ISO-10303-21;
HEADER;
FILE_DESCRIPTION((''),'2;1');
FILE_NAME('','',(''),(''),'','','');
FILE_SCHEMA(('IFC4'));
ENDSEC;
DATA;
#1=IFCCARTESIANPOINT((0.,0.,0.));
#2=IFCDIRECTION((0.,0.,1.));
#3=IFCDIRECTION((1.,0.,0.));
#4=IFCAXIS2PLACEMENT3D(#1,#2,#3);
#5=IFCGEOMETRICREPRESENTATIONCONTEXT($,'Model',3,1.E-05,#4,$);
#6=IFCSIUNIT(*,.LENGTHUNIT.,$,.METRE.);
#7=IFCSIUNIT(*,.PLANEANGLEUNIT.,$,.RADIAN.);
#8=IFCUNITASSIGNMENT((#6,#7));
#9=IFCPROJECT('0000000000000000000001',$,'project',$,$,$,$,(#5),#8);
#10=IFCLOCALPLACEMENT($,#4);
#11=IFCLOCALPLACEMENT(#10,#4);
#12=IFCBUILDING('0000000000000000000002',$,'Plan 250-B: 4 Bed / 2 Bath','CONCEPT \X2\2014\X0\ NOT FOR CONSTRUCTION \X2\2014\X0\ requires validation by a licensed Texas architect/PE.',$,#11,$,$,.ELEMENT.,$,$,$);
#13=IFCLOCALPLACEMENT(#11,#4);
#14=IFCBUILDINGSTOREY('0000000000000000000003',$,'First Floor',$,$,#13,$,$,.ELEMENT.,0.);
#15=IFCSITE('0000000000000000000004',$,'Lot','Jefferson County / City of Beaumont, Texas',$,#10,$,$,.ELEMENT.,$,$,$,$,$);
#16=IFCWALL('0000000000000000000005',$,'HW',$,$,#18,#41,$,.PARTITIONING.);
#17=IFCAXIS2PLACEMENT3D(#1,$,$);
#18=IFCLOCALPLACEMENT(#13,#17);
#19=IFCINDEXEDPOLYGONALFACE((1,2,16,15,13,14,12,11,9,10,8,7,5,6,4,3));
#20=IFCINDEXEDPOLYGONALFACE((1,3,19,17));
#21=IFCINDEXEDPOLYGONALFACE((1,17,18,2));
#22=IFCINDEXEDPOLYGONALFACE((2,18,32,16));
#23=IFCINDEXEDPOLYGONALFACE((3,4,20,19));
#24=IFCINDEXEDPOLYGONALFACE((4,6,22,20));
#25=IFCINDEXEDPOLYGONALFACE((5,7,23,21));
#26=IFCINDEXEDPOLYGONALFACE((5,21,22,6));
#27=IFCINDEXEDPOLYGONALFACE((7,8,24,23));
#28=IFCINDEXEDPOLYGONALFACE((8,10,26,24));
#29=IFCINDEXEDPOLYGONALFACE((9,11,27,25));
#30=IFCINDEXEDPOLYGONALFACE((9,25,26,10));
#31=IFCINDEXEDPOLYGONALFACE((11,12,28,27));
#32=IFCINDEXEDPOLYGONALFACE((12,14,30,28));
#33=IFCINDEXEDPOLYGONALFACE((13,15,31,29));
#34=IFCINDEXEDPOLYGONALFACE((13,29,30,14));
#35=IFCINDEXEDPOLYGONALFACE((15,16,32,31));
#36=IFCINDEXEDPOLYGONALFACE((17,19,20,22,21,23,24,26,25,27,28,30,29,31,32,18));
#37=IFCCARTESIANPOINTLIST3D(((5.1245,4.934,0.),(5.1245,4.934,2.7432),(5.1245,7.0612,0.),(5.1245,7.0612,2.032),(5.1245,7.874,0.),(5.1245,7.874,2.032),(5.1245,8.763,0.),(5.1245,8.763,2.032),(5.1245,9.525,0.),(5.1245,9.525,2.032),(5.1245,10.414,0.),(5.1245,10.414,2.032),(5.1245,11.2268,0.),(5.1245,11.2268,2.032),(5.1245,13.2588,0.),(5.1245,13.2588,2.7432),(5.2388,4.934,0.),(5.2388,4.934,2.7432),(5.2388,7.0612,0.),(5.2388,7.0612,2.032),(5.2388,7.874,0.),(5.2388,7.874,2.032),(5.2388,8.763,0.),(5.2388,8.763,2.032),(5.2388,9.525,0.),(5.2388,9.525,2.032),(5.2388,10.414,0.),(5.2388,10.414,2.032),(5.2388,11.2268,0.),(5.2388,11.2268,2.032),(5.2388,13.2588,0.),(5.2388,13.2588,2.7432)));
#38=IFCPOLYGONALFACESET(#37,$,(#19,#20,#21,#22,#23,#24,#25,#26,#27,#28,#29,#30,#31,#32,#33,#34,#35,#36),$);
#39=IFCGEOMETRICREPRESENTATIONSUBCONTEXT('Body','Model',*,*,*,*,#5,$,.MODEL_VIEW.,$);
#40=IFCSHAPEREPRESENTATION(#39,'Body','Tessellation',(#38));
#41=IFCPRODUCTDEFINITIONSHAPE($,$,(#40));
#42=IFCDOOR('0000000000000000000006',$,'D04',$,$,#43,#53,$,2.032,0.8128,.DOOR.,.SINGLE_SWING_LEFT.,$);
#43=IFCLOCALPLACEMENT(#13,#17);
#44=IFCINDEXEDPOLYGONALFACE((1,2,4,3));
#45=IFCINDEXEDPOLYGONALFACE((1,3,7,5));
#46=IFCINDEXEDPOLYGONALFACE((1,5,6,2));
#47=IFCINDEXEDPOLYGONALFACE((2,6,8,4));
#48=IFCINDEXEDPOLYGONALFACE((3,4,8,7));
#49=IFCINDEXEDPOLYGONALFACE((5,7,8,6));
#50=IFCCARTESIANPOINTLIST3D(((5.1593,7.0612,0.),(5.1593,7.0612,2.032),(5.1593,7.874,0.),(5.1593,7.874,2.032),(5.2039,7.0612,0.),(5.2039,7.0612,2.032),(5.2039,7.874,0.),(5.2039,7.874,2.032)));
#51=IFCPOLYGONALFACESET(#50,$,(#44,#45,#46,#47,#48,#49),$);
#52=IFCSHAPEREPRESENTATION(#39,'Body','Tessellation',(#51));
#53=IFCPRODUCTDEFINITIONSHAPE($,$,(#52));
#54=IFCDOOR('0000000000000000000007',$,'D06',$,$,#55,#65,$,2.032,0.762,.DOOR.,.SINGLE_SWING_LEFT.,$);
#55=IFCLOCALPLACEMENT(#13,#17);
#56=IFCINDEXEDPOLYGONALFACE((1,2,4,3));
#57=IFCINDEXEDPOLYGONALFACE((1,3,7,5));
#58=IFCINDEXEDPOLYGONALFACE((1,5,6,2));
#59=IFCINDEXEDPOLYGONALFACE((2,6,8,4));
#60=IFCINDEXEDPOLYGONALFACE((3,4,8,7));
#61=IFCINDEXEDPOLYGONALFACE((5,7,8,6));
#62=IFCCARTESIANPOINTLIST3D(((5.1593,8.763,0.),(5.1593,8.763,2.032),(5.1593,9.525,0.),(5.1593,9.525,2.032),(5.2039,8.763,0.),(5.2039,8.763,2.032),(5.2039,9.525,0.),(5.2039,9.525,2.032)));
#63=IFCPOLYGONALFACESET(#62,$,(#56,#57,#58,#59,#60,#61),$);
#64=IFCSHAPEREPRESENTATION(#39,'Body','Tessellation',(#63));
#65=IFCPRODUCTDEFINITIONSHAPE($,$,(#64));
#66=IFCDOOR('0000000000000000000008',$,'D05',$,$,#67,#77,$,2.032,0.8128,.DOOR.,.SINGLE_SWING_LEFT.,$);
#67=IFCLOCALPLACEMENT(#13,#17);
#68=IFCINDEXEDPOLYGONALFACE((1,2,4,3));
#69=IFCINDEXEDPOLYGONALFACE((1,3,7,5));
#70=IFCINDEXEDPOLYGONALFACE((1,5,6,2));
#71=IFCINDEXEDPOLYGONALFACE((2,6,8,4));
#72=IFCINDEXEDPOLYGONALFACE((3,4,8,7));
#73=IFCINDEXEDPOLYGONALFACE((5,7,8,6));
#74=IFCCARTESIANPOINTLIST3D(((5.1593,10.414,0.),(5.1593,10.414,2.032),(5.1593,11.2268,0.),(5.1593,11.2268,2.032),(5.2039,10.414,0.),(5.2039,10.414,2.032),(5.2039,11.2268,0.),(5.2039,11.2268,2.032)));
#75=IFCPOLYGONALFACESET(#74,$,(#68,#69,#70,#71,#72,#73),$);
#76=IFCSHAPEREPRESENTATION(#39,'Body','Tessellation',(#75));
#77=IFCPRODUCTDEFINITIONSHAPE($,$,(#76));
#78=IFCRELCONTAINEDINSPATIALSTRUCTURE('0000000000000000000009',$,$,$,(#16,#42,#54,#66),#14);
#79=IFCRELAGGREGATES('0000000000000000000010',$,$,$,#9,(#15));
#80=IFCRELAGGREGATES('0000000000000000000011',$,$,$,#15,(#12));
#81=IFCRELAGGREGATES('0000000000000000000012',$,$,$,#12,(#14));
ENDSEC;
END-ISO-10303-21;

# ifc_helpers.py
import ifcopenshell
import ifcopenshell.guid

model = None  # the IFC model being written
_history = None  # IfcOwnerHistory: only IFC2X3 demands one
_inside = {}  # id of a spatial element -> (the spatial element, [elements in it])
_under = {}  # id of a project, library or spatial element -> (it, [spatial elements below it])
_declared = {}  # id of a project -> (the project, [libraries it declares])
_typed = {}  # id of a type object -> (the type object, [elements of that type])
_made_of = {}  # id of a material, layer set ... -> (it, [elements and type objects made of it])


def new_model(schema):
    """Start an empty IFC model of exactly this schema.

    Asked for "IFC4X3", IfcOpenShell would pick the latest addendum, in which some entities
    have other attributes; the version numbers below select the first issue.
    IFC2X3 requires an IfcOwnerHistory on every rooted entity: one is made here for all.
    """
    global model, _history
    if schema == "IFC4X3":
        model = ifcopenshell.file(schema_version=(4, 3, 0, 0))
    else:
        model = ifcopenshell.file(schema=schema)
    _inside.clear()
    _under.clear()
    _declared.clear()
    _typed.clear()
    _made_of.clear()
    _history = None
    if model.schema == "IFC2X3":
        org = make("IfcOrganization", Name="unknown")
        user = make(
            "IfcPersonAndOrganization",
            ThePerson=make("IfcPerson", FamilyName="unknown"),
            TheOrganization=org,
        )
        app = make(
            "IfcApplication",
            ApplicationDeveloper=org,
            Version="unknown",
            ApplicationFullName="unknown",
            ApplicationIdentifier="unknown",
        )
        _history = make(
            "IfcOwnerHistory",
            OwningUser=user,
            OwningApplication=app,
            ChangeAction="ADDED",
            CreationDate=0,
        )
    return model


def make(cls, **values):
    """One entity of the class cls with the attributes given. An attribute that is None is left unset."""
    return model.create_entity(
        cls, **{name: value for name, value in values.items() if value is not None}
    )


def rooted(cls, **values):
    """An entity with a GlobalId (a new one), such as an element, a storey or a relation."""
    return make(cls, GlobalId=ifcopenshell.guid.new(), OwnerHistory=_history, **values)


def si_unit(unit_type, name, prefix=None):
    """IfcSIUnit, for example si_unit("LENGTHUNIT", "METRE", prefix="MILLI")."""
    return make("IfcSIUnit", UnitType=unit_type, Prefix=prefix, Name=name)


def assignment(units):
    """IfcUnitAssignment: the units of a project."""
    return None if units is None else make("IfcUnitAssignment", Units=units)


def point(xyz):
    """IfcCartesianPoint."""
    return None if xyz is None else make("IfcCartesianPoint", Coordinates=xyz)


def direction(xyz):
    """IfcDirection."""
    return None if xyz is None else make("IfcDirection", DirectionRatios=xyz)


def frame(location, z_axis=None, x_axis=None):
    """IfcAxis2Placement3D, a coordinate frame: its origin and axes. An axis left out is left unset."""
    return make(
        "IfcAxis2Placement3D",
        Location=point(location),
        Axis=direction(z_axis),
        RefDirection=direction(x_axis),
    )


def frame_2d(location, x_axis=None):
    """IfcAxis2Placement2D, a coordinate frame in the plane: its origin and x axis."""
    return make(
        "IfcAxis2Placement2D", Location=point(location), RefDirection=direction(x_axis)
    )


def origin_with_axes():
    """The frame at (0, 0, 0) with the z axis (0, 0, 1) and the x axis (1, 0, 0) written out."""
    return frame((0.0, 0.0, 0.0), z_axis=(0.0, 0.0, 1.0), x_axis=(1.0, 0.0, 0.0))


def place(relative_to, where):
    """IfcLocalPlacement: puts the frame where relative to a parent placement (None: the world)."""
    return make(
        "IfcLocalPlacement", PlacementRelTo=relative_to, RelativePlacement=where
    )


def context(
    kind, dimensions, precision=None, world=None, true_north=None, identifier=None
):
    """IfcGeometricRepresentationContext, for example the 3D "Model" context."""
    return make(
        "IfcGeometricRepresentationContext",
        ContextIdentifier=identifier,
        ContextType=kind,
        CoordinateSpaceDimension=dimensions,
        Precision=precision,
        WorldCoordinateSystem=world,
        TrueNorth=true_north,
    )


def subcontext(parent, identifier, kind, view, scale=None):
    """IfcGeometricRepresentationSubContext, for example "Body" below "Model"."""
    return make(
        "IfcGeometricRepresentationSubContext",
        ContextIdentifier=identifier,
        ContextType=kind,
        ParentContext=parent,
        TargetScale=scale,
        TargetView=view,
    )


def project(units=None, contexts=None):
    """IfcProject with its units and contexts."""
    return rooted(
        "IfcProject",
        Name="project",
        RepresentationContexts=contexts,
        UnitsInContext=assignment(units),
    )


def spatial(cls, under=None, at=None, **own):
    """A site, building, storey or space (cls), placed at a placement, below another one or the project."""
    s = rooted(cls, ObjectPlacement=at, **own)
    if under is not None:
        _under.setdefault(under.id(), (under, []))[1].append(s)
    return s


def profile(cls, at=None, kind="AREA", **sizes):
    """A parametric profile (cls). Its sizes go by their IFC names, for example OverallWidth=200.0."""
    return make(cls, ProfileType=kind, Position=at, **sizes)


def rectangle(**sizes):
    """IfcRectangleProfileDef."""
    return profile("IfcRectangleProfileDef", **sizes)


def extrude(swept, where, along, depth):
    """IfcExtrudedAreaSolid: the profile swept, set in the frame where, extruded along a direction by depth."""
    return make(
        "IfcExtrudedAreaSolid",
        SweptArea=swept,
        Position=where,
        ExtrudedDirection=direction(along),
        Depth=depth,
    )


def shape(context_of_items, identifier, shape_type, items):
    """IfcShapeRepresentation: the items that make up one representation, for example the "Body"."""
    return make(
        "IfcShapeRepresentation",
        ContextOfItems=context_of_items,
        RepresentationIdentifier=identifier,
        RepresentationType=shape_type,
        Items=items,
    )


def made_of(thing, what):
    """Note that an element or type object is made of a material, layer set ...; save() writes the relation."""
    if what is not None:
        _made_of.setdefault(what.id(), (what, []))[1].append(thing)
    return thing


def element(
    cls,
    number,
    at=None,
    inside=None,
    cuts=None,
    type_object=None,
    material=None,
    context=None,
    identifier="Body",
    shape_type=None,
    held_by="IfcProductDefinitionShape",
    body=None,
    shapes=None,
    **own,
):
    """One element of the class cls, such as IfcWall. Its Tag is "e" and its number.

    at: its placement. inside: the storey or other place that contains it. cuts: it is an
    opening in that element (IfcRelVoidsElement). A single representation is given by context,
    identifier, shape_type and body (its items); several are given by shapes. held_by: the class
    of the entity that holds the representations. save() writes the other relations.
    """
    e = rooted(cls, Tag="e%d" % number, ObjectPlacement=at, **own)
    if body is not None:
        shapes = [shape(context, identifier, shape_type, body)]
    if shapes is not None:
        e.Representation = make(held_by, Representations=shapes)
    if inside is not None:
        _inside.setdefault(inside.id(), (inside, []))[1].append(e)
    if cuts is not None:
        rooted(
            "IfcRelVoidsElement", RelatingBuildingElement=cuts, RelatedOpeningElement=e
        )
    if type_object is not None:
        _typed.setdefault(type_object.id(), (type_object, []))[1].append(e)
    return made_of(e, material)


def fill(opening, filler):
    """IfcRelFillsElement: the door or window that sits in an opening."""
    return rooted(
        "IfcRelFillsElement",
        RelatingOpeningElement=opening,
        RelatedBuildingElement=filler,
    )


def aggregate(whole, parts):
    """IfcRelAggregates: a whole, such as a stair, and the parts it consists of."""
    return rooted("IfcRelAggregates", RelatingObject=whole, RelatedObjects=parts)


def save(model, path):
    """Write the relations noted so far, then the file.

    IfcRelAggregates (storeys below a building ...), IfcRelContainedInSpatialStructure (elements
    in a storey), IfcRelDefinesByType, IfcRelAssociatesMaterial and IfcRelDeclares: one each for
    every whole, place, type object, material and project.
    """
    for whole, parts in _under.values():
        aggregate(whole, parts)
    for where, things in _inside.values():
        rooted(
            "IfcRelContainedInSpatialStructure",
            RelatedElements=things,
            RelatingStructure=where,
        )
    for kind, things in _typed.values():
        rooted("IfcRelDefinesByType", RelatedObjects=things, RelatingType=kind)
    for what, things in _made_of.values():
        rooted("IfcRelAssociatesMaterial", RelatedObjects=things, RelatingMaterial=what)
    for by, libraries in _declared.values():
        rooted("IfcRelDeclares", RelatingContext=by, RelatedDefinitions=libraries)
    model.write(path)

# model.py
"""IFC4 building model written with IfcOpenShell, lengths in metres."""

from ifc_helpers import new_model, si_unit, frame, frame_2d, origin_with_axes, place, context, subcontext, project, spatial, rectangle, extrude, element, fill, save


model = new_model("IFC4")

# Units and contexts
model_context = context("Model", 3, precision=1e-05, world=origin_with_axes())
body_context = subcontext(model_context, "Body", "Model", "MODEL_VIEW")
ifc_project = project(units=[si_unit("LENGTHUNIT", "METRE"), si_unit("PLANEANGLEUNIT", "RADIAN")], contexts=[model_context])

# Site, building, storey
site_placement = place(None, origin_with_axes())
site = spatial("IfcSite", under=ifc_project, at=site_placement, Name="Lot", Description="Jefferson County / City of Beaumont, Texas", CompositionType="ELEMENT")
building_placement = place(site_placement, origin_with_axes())
building = spatial("IfcBuilding", under=site, at=building_placement, Name="Plan 250-B: 4 Bed / 2 Bath", Description="CONCEPT — NOT FOR CONSTRUCTION — requires validation by a licensed Texas architect/PE.", CompositionType="ELEMENT")
storey_placement = place(building_placement, origin_with_axes())
storey = spatial("IfcBuildingStorey", under=building, at=storey_placement, Name="First Floor", CompositionType="ELEMENT", Elevation=0.0)

# Wall, openings, doors
wall_1_placement = place(storey_placement, frame((5.1816, 4.934, 0.0), z_axis=(0.0, 0.0, 1.0), x_axis=(0.0, 1.0, 0.0)))
wall_1 = element("IfcWall", 1, at=wall_1_placement, inside=storey, Name="HW", PredefinedType="PARTITIONING", context=body_context, shape_type="SweptSolid", body=[
    extrude(rectangle(XDim=8.3248, YDim=0.1143, at=frame_2d((4.1624, 0.0), x_axis=(1.0, 0.0))), origin_with_axes(), (0.0, 0.0, 1.0), 2.7432),
])
opening_1_placement = place(wall_1_placement, frame((2.1272, 0.0, 0.0), z_axis=(0.0, 0.0, 1.0), x_axis=(1.0, 0.0, 0.0)))
opening_1 = element("IfcOpeningElement", 2, at=opening_1_placement, cuts=wall_1, PredefinedType="OPENING", context=body_context, shape_type="SweptSolid", body=[
    extrude(rectangle(XDim=0.8128, YDim=0.1448, at=frame_2d((0.4064, 0.0), x_axis=(1.0, 0.0))), origin_with_axes(), (0.0, 0.0, 1.0), 2.032),
])
opening_2_placement = place(wall_1_placement, frame((3.8291, 0.0, 0.0), z_axis=(0.0, 0.0, 1.0), x_axis=(1.0, 0.0, 0.0)))
opening_2 = element("IfcOpeningElement", 3, at=opening_2_placement, cuts=wall_1, PredefinedType="OPENING", context=body_context, shape_type="SweptSolid", body=[
    extrude(rectangle(XDim=0.762, YDim=0.1448, at=frame_2d((0.381, 0.0), x_axis=(1.0, 0.0))), origin_with_axes(), (0.0, 0.0, 1.0), 2.032),
])
opening_3_placement = place(wall_1_placement, frame((5.48, 0.0, 0.0), z_axis=(0.0, 0.0, 1.0), x_axis=(1.0, 0.0, 0.0)))
opening_3 = element("IfcOpeningElement", 4, at=opening_3_placement, cuts=wall_1, PredefinedType="OPENING", context=body_context, shape_type="SweptSolid", body=[
    extrude(rectangle(XDim=0.8128, YDim=0.1448, at=frame_2d((0.4064, 0.0), x_axis=(1.0, 0.0))), origin_with_axes(), (0.0, 0.0, 1.0), 2.032),
])
door_1_placement = place(opening_1_placement, origin_with_axes())
door_1 = element("IfcDoor", 5, at=door_1_placement, inside=storey, Name="D04", OperationType="SINGLE_SWING_LEFT", OverallHeight=2.032, OverallWidth=0.8128, PredefinedType="DOOR", context=body_context, shape_type="SweptSolid", body=[
    extrude(rectangle(XDim=0.8128, YDim=0.0445, at=frame_2d((0.4064, 0.0), x_axis=(1.0, 0.0))), origin_with_axes(), (0.0, 0.0, 1.0), 2.032),
])
fill(opening_1, door_1)
door_2_placement = place(opening_2_placement, origin_with_axes())
door_2 = element("IfcDoor", 6, at=door_2_placement, inside=storey, Name="D06", OperationType="SINGLE_SWING_LEFT", OverallHeight=2.032, OverallWidth=0.762, PredefinedType="DOOR", context=body_context, shape_type="SweptSolid", body=[
    extrude(rectangle(XDim=0.762, YDim=0.0445, at=frame_2d((0.381, 0.0), x_axis=(1.0, 0.0))), origin_with_axes(), (0.0, 0.0, 1.0), 2.032),
])
fill(opening_2, door_2)
door_3_placement = place(opening_3_placement, origin_with_axes())
door_3 = element("IfcDoor", 7, at=door_3_placement, inside=storey, Name="D05", OperationType="SINGLE_SWING_LEFT", OverallHeight=2.032, OverallWidth=0.8128, PredefinedType="DOOR", context=body_context, shape_type="SweptSolid", body=[
    extrude(rectangle(XDim=0.8128, YDim=0.0445, at=frame_2d((0.4064, 0.0), x_axis=(1.0, 0.0))), origin_with_axes(), (0.0, 0.0, 1.0), 2.032),
])
fill(opening_3, door_3)

save(model, "model.ifc")
